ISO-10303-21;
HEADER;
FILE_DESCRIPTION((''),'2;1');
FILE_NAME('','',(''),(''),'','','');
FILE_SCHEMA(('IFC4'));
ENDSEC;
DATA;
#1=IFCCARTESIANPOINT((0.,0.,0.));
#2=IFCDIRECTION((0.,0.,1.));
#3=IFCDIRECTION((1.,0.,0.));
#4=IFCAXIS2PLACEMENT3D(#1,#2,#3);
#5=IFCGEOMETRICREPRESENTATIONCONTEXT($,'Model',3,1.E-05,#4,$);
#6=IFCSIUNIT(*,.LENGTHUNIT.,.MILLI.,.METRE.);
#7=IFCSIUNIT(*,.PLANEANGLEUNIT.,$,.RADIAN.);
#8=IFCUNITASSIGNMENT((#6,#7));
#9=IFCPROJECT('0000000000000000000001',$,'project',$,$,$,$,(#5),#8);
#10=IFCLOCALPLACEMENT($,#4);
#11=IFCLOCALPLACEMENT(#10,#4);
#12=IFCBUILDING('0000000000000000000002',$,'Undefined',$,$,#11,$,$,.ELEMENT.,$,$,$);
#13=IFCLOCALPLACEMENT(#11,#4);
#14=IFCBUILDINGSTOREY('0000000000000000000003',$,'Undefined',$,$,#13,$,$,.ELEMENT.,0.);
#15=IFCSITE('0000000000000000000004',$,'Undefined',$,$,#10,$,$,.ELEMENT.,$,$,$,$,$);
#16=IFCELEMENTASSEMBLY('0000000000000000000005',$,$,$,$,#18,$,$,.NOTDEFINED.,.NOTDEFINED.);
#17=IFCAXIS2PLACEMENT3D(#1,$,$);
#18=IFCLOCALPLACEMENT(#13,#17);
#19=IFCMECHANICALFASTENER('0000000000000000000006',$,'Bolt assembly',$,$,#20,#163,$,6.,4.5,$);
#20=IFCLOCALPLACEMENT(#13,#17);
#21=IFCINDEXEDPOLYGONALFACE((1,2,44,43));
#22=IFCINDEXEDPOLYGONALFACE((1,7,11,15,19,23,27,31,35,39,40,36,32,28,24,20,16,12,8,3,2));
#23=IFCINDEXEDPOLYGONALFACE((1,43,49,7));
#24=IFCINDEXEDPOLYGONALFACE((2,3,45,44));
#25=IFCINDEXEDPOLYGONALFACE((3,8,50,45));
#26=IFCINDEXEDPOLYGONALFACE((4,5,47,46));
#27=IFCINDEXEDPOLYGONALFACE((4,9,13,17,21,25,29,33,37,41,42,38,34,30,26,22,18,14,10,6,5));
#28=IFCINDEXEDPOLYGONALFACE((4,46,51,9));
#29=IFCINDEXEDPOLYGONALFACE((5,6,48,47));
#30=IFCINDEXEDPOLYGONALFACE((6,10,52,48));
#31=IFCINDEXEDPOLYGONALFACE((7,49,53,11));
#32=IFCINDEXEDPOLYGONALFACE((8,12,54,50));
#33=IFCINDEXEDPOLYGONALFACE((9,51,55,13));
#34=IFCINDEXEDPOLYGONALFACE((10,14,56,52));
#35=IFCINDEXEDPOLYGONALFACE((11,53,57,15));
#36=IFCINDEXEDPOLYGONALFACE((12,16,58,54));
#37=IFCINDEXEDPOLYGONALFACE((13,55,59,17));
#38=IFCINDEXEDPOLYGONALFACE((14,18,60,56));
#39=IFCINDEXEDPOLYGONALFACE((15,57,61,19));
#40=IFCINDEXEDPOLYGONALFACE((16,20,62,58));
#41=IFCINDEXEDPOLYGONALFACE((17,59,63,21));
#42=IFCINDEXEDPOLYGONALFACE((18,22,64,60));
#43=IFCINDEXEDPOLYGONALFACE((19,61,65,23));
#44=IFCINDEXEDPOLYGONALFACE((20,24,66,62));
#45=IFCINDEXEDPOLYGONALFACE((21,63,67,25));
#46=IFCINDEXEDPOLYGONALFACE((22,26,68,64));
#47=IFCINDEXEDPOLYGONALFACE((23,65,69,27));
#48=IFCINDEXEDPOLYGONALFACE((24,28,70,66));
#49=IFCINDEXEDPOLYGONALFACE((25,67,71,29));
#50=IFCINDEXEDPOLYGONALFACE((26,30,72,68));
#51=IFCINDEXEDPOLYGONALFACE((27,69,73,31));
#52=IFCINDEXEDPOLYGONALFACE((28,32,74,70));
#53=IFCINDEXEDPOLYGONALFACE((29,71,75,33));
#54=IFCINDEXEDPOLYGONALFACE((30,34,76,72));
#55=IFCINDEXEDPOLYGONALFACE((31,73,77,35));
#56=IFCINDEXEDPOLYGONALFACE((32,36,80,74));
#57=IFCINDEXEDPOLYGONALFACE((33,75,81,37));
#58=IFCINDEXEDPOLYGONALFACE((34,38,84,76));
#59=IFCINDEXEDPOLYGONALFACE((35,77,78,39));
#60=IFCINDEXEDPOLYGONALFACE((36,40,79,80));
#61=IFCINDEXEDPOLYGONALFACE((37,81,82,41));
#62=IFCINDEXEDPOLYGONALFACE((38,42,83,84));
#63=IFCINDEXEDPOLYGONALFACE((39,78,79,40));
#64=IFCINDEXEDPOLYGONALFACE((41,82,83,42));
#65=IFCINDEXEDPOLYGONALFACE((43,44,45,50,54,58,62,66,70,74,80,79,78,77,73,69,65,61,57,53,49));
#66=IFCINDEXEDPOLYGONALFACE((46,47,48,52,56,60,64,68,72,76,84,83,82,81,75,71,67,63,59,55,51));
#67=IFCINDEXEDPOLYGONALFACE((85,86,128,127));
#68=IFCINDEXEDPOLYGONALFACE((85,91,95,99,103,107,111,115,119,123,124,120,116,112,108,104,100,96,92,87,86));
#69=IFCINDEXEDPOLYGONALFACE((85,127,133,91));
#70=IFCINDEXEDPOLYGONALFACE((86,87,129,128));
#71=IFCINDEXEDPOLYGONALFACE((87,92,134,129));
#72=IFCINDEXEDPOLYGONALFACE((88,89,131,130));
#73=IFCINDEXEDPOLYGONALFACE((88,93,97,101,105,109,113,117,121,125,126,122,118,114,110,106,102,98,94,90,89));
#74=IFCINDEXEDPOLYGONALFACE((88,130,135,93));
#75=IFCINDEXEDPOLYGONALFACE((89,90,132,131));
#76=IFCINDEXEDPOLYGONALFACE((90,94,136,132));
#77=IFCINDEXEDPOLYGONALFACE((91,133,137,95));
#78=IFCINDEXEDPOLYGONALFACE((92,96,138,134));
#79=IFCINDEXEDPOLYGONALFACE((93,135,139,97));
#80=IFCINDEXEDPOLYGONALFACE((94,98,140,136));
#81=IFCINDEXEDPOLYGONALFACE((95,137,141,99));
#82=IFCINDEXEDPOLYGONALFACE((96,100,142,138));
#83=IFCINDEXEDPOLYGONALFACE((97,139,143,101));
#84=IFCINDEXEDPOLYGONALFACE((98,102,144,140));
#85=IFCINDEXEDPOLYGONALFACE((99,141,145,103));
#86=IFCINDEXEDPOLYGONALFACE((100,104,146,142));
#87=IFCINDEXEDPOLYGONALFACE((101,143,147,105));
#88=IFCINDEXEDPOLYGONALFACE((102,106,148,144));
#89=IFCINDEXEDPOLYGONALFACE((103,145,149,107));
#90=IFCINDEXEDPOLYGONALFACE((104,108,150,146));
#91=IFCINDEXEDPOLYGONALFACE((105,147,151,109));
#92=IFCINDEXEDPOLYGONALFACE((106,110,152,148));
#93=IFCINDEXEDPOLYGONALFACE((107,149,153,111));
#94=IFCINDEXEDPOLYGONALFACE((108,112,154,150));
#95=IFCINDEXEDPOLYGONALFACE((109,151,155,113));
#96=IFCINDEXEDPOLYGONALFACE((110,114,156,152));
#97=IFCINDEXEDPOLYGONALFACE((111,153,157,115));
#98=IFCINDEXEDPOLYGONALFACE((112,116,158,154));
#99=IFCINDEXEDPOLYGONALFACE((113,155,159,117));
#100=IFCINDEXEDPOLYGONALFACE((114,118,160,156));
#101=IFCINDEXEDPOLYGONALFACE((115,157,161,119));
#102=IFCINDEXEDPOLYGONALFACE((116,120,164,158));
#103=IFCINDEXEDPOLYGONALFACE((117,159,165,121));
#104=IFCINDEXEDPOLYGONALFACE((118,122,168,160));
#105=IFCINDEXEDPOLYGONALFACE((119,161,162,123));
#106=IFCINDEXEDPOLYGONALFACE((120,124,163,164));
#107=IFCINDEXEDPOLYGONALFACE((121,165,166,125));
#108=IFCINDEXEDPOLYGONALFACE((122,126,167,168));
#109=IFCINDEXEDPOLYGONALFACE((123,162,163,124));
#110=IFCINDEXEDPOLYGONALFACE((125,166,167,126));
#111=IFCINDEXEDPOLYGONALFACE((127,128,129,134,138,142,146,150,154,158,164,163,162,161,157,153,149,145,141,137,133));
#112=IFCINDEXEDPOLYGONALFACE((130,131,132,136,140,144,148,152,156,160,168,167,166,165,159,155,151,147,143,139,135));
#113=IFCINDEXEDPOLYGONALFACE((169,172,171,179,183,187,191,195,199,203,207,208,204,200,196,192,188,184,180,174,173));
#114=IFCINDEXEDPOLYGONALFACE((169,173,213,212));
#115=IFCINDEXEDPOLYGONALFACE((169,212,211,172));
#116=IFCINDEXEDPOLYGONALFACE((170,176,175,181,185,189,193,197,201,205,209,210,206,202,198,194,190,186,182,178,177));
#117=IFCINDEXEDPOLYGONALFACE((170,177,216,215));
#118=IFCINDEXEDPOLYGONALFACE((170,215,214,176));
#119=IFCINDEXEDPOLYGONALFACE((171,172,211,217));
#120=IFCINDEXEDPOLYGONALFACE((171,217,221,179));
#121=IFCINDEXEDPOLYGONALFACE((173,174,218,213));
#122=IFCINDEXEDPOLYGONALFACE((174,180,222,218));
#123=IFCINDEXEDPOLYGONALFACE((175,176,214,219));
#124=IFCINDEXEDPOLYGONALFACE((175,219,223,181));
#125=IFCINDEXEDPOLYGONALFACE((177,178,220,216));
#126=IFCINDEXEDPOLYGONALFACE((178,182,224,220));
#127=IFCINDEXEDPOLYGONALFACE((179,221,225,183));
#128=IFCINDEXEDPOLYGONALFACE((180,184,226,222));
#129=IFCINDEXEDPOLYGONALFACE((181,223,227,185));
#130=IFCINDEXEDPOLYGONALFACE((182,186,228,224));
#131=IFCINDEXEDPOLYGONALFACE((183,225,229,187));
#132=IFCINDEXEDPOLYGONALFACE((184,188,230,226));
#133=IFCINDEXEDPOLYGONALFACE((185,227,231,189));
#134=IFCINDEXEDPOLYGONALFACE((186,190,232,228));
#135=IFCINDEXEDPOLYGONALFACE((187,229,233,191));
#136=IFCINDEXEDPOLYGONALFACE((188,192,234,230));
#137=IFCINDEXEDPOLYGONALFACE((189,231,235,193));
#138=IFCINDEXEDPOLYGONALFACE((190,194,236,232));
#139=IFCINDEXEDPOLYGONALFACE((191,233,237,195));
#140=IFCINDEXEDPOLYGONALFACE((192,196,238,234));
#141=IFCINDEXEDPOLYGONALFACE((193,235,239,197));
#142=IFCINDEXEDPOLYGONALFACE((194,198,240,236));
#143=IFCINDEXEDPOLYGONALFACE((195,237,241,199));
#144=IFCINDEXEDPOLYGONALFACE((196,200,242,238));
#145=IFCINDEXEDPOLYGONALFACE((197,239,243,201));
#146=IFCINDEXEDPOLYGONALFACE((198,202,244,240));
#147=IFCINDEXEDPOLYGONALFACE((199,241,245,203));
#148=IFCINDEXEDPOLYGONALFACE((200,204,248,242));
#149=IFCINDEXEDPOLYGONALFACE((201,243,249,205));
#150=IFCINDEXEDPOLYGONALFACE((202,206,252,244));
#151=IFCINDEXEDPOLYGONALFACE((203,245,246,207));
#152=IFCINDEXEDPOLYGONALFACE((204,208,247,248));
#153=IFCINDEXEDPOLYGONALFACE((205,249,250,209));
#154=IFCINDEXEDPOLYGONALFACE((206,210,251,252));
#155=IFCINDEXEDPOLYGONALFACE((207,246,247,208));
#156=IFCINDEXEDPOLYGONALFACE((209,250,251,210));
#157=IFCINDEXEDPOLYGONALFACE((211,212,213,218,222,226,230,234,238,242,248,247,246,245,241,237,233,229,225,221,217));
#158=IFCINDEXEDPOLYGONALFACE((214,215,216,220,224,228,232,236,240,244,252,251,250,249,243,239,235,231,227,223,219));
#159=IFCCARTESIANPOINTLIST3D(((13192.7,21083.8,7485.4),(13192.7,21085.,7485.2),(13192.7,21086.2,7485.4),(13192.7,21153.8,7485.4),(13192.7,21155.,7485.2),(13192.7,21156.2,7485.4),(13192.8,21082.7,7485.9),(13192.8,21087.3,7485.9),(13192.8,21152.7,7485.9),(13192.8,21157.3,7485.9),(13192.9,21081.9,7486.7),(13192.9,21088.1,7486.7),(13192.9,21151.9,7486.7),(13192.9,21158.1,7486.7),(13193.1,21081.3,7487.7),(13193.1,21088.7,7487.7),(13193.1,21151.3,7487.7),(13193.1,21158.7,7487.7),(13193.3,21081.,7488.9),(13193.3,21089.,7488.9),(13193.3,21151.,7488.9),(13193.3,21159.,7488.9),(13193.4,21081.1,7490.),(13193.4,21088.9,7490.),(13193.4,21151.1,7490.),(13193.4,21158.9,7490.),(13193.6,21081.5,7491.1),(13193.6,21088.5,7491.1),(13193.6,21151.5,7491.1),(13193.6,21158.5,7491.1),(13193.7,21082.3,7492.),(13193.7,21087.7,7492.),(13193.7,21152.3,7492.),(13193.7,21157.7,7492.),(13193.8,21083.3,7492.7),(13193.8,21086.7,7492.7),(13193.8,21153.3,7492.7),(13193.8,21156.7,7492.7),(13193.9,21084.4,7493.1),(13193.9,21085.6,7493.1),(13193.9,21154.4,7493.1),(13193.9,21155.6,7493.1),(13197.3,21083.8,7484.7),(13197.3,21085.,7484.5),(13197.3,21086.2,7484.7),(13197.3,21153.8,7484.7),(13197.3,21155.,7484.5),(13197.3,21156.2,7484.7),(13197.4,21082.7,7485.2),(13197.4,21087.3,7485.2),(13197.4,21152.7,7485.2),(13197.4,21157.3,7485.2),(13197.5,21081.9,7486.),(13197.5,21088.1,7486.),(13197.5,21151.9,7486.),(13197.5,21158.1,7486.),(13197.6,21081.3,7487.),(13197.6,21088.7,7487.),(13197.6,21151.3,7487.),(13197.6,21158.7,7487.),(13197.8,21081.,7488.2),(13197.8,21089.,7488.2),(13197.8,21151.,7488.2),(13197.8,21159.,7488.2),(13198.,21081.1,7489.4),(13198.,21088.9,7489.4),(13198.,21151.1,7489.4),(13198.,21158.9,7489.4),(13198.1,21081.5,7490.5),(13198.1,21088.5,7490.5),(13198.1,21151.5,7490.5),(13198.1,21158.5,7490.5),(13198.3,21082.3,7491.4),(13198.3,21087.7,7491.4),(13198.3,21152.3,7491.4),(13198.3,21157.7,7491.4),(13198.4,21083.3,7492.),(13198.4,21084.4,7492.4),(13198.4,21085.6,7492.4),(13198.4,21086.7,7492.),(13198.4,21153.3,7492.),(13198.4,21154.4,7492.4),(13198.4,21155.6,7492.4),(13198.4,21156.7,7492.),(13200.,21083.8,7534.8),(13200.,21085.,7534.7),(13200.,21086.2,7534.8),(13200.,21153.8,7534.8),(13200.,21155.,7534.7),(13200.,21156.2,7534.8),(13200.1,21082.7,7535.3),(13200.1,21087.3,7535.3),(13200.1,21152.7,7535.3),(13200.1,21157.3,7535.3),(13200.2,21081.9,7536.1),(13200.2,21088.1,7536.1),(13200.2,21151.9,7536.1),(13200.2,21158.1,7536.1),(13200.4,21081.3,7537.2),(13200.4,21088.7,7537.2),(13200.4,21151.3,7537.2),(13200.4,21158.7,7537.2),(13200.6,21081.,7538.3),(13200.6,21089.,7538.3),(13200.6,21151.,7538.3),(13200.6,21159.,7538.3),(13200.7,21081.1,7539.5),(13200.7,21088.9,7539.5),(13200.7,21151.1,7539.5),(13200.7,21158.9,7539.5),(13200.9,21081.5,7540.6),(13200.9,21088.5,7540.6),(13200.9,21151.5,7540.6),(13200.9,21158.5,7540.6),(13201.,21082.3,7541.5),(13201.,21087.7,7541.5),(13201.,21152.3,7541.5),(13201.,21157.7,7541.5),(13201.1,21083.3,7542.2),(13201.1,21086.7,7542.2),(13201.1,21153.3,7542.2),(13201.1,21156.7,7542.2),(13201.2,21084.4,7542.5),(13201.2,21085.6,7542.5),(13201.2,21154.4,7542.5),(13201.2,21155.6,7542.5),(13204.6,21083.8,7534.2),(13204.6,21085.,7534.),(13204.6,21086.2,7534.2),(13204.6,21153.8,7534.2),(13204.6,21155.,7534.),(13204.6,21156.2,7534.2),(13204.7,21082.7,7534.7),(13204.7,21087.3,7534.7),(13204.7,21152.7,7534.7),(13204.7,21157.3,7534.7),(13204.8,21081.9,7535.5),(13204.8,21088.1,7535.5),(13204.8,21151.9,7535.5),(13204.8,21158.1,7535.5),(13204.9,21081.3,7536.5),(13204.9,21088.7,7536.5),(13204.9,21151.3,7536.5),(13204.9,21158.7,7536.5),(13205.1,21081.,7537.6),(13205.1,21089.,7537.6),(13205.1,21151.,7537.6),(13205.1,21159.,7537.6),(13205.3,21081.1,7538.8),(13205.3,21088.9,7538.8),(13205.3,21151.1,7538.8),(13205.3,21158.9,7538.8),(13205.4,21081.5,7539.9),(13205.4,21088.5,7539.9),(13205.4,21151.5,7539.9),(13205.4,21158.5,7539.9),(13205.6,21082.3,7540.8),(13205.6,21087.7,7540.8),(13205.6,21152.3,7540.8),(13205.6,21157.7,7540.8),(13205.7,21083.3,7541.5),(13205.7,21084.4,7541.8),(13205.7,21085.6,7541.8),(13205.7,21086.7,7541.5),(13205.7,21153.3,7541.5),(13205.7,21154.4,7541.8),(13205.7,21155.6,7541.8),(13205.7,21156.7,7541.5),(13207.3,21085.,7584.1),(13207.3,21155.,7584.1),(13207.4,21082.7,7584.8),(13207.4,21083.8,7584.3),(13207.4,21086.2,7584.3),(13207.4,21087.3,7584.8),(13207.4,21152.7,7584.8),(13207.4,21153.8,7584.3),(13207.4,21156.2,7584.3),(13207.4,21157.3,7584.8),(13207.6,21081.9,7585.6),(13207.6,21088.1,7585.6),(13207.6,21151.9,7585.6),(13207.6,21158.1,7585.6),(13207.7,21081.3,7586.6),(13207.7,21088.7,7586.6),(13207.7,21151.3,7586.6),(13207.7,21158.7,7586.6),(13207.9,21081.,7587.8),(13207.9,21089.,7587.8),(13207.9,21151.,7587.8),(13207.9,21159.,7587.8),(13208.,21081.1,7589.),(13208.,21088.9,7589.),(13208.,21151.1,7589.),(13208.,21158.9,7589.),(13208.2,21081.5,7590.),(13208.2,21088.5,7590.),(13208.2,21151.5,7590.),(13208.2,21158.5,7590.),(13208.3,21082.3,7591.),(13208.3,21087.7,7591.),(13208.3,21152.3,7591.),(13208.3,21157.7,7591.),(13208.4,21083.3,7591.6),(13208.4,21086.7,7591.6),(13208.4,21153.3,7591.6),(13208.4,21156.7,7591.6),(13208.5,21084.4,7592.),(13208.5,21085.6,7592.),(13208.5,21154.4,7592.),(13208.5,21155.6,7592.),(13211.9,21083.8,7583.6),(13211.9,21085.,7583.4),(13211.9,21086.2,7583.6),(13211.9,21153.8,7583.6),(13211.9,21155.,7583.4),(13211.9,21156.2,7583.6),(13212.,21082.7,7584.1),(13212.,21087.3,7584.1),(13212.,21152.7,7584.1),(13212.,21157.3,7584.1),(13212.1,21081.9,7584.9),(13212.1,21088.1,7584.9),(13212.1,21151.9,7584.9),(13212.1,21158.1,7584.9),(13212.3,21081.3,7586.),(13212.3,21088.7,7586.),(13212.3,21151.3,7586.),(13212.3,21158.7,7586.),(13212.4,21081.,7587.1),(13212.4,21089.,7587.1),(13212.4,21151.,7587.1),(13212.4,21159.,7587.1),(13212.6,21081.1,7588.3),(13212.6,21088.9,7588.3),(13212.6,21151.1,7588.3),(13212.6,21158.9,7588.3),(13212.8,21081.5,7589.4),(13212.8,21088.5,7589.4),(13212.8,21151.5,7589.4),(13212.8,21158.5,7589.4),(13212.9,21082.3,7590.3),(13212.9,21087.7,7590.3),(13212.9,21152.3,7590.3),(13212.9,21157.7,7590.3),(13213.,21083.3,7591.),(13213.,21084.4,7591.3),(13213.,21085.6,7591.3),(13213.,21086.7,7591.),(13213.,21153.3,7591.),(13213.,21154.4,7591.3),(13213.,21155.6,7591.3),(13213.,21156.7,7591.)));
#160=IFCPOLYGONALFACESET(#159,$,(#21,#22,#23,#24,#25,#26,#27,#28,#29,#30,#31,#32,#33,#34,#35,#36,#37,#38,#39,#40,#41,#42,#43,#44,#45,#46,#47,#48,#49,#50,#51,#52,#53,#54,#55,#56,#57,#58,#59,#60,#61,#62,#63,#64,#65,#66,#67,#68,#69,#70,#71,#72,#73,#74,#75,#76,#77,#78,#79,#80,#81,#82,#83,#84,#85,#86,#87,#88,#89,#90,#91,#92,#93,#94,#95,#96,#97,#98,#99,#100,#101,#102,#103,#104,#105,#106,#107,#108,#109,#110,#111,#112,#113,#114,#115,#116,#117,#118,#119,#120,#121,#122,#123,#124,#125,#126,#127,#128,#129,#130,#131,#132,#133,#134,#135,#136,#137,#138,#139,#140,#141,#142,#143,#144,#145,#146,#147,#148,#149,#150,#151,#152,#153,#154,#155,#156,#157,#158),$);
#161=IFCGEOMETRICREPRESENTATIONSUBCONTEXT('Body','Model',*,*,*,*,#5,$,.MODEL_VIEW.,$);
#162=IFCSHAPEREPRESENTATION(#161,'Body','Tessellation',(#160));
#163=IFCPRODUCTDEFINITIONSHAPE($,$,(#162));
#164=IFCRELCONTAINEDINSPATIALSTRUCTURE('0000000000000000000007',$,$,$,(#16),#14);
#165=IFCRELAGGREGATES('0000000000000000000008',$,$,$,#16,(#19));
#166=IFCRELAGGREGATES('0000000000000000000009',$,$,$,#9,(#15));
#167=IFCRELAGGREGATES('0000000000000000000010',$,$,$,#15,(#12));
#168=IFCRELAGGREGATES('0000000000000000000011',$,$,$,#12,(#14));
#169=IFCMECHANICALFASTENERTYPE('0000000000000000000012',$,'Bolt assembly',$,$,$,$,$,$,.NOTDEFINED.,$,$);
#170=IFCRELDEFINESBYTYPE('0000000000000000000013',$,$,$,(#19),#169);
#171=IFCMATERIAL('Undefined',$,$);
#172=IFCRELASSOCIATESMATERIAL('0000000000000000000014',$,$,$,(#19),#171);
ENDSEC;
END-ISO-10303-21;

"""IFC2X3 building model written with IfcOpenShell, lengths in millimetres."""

from ifc_helpers import new_model, si_unit, frame, origin_with_axes, origin_2d_with_axis, place, context, subcontext, project, spatial, circle, extrude, source, transform, mapped, material, type_object, element, aggregate, save


model = new_model("IFC2X3")

# Units and contexts
model_context = context("Model", 3, precision=1e-05, world=origin_with_axes())
body_context = subcontext(model_context, "Body", "Model", "MODEL_VIEW")
ifc_project = project(units=[si_unit("LENGTHUNIT", "METRE", prefix="MILLI"), si_unit("PLANEANGLEUNIT", "RADIAN")], contexts=[model_context])

# Site, building, storey
site_placement = place(None, origin_with_axes())
site = spatial("IfcSite", under=ifc_project, at=site_placement, Name="Undefined", CompositionType="ELEMENT")
building_placement = place(site_placement, origin_with_axes())
building = spatial("IfcBuilding", under=site, at=building_placement, Name="Undefined", CompositionType="ELEMENT")
storey_placement = place(building_placement, origin_with_axes())
storey = spatial("IfcBuildingStorey", under=building, at=storey_placement, Name="Undefined", CompositionType="ELEMENT", Elevation=0.0)

# Element assembly
assembly_1_placement = place(storey_placement, origin_with_axes())
assembly_1 = element("IfcElementAssembly", 1, at=assembly_1_placement, inside=storey, AssemblyPlace="NOTDEFINED", PredefinedType="NOTDEFINED")

# Mechanical fastener
ifc_material_1 = material(Name="Undefined")
mechanical_fastener_type = type_object("IfcMechanicalFastenerType", Name="Bolt assembly")
shared_shape_1 = source(origin_with_axes(), body_context, "Body", "SweptSolid", [
    extrude(circle(Radius=4.0, at=origin_2d_with_axis()), frame((0.0, 0.0, 0.0), z_axis=(0.0, 1.0, 0.0), x_axis=(1.0, 0.0, 0.0)), (0.0, 0.0, 1.0), 4.6),
])
mechanical_fastener_1_placement = place(assembly_1_placement, frame((13212.5, 21120.0, 7587.4), z_axis=(0.0, 1.0, 0.0), x_axis=(-0.146202, 0.0, -0.989255)))
mechanical_fastener_1 = element("IfcMechanicalFastener", 2, at=mechanical_fastener_1_placement, type_object=mechanical_fastener_type, material=ifc_material_1, Name="Bolt assembly", NominalDiameter=6.0, NominalLength=4.5, context=body_context, shape_type="MappedRepresentation", body=[
    mapped(shared_shape_1, transform((0.0, 0.0, 35.0))),
    mapped(shared_shape_1, transform((50.0, 0.0, 35.0))),
    mapped(shared_shape_1, transform((100.0, 0.0, 35.0))),
    mapped(shared_shape_1, transform((0.0, 0.0, -35.0))),
    mapped(shared_shape_1, transform((50.0, 0.0, -35.0))),
    mapped(shared_shape_1, transform((100.0, 0.0, -35.0))),
])

aggregate(assembly_1, [mechanical_fastener_1])

save(model, "model.ifc")
